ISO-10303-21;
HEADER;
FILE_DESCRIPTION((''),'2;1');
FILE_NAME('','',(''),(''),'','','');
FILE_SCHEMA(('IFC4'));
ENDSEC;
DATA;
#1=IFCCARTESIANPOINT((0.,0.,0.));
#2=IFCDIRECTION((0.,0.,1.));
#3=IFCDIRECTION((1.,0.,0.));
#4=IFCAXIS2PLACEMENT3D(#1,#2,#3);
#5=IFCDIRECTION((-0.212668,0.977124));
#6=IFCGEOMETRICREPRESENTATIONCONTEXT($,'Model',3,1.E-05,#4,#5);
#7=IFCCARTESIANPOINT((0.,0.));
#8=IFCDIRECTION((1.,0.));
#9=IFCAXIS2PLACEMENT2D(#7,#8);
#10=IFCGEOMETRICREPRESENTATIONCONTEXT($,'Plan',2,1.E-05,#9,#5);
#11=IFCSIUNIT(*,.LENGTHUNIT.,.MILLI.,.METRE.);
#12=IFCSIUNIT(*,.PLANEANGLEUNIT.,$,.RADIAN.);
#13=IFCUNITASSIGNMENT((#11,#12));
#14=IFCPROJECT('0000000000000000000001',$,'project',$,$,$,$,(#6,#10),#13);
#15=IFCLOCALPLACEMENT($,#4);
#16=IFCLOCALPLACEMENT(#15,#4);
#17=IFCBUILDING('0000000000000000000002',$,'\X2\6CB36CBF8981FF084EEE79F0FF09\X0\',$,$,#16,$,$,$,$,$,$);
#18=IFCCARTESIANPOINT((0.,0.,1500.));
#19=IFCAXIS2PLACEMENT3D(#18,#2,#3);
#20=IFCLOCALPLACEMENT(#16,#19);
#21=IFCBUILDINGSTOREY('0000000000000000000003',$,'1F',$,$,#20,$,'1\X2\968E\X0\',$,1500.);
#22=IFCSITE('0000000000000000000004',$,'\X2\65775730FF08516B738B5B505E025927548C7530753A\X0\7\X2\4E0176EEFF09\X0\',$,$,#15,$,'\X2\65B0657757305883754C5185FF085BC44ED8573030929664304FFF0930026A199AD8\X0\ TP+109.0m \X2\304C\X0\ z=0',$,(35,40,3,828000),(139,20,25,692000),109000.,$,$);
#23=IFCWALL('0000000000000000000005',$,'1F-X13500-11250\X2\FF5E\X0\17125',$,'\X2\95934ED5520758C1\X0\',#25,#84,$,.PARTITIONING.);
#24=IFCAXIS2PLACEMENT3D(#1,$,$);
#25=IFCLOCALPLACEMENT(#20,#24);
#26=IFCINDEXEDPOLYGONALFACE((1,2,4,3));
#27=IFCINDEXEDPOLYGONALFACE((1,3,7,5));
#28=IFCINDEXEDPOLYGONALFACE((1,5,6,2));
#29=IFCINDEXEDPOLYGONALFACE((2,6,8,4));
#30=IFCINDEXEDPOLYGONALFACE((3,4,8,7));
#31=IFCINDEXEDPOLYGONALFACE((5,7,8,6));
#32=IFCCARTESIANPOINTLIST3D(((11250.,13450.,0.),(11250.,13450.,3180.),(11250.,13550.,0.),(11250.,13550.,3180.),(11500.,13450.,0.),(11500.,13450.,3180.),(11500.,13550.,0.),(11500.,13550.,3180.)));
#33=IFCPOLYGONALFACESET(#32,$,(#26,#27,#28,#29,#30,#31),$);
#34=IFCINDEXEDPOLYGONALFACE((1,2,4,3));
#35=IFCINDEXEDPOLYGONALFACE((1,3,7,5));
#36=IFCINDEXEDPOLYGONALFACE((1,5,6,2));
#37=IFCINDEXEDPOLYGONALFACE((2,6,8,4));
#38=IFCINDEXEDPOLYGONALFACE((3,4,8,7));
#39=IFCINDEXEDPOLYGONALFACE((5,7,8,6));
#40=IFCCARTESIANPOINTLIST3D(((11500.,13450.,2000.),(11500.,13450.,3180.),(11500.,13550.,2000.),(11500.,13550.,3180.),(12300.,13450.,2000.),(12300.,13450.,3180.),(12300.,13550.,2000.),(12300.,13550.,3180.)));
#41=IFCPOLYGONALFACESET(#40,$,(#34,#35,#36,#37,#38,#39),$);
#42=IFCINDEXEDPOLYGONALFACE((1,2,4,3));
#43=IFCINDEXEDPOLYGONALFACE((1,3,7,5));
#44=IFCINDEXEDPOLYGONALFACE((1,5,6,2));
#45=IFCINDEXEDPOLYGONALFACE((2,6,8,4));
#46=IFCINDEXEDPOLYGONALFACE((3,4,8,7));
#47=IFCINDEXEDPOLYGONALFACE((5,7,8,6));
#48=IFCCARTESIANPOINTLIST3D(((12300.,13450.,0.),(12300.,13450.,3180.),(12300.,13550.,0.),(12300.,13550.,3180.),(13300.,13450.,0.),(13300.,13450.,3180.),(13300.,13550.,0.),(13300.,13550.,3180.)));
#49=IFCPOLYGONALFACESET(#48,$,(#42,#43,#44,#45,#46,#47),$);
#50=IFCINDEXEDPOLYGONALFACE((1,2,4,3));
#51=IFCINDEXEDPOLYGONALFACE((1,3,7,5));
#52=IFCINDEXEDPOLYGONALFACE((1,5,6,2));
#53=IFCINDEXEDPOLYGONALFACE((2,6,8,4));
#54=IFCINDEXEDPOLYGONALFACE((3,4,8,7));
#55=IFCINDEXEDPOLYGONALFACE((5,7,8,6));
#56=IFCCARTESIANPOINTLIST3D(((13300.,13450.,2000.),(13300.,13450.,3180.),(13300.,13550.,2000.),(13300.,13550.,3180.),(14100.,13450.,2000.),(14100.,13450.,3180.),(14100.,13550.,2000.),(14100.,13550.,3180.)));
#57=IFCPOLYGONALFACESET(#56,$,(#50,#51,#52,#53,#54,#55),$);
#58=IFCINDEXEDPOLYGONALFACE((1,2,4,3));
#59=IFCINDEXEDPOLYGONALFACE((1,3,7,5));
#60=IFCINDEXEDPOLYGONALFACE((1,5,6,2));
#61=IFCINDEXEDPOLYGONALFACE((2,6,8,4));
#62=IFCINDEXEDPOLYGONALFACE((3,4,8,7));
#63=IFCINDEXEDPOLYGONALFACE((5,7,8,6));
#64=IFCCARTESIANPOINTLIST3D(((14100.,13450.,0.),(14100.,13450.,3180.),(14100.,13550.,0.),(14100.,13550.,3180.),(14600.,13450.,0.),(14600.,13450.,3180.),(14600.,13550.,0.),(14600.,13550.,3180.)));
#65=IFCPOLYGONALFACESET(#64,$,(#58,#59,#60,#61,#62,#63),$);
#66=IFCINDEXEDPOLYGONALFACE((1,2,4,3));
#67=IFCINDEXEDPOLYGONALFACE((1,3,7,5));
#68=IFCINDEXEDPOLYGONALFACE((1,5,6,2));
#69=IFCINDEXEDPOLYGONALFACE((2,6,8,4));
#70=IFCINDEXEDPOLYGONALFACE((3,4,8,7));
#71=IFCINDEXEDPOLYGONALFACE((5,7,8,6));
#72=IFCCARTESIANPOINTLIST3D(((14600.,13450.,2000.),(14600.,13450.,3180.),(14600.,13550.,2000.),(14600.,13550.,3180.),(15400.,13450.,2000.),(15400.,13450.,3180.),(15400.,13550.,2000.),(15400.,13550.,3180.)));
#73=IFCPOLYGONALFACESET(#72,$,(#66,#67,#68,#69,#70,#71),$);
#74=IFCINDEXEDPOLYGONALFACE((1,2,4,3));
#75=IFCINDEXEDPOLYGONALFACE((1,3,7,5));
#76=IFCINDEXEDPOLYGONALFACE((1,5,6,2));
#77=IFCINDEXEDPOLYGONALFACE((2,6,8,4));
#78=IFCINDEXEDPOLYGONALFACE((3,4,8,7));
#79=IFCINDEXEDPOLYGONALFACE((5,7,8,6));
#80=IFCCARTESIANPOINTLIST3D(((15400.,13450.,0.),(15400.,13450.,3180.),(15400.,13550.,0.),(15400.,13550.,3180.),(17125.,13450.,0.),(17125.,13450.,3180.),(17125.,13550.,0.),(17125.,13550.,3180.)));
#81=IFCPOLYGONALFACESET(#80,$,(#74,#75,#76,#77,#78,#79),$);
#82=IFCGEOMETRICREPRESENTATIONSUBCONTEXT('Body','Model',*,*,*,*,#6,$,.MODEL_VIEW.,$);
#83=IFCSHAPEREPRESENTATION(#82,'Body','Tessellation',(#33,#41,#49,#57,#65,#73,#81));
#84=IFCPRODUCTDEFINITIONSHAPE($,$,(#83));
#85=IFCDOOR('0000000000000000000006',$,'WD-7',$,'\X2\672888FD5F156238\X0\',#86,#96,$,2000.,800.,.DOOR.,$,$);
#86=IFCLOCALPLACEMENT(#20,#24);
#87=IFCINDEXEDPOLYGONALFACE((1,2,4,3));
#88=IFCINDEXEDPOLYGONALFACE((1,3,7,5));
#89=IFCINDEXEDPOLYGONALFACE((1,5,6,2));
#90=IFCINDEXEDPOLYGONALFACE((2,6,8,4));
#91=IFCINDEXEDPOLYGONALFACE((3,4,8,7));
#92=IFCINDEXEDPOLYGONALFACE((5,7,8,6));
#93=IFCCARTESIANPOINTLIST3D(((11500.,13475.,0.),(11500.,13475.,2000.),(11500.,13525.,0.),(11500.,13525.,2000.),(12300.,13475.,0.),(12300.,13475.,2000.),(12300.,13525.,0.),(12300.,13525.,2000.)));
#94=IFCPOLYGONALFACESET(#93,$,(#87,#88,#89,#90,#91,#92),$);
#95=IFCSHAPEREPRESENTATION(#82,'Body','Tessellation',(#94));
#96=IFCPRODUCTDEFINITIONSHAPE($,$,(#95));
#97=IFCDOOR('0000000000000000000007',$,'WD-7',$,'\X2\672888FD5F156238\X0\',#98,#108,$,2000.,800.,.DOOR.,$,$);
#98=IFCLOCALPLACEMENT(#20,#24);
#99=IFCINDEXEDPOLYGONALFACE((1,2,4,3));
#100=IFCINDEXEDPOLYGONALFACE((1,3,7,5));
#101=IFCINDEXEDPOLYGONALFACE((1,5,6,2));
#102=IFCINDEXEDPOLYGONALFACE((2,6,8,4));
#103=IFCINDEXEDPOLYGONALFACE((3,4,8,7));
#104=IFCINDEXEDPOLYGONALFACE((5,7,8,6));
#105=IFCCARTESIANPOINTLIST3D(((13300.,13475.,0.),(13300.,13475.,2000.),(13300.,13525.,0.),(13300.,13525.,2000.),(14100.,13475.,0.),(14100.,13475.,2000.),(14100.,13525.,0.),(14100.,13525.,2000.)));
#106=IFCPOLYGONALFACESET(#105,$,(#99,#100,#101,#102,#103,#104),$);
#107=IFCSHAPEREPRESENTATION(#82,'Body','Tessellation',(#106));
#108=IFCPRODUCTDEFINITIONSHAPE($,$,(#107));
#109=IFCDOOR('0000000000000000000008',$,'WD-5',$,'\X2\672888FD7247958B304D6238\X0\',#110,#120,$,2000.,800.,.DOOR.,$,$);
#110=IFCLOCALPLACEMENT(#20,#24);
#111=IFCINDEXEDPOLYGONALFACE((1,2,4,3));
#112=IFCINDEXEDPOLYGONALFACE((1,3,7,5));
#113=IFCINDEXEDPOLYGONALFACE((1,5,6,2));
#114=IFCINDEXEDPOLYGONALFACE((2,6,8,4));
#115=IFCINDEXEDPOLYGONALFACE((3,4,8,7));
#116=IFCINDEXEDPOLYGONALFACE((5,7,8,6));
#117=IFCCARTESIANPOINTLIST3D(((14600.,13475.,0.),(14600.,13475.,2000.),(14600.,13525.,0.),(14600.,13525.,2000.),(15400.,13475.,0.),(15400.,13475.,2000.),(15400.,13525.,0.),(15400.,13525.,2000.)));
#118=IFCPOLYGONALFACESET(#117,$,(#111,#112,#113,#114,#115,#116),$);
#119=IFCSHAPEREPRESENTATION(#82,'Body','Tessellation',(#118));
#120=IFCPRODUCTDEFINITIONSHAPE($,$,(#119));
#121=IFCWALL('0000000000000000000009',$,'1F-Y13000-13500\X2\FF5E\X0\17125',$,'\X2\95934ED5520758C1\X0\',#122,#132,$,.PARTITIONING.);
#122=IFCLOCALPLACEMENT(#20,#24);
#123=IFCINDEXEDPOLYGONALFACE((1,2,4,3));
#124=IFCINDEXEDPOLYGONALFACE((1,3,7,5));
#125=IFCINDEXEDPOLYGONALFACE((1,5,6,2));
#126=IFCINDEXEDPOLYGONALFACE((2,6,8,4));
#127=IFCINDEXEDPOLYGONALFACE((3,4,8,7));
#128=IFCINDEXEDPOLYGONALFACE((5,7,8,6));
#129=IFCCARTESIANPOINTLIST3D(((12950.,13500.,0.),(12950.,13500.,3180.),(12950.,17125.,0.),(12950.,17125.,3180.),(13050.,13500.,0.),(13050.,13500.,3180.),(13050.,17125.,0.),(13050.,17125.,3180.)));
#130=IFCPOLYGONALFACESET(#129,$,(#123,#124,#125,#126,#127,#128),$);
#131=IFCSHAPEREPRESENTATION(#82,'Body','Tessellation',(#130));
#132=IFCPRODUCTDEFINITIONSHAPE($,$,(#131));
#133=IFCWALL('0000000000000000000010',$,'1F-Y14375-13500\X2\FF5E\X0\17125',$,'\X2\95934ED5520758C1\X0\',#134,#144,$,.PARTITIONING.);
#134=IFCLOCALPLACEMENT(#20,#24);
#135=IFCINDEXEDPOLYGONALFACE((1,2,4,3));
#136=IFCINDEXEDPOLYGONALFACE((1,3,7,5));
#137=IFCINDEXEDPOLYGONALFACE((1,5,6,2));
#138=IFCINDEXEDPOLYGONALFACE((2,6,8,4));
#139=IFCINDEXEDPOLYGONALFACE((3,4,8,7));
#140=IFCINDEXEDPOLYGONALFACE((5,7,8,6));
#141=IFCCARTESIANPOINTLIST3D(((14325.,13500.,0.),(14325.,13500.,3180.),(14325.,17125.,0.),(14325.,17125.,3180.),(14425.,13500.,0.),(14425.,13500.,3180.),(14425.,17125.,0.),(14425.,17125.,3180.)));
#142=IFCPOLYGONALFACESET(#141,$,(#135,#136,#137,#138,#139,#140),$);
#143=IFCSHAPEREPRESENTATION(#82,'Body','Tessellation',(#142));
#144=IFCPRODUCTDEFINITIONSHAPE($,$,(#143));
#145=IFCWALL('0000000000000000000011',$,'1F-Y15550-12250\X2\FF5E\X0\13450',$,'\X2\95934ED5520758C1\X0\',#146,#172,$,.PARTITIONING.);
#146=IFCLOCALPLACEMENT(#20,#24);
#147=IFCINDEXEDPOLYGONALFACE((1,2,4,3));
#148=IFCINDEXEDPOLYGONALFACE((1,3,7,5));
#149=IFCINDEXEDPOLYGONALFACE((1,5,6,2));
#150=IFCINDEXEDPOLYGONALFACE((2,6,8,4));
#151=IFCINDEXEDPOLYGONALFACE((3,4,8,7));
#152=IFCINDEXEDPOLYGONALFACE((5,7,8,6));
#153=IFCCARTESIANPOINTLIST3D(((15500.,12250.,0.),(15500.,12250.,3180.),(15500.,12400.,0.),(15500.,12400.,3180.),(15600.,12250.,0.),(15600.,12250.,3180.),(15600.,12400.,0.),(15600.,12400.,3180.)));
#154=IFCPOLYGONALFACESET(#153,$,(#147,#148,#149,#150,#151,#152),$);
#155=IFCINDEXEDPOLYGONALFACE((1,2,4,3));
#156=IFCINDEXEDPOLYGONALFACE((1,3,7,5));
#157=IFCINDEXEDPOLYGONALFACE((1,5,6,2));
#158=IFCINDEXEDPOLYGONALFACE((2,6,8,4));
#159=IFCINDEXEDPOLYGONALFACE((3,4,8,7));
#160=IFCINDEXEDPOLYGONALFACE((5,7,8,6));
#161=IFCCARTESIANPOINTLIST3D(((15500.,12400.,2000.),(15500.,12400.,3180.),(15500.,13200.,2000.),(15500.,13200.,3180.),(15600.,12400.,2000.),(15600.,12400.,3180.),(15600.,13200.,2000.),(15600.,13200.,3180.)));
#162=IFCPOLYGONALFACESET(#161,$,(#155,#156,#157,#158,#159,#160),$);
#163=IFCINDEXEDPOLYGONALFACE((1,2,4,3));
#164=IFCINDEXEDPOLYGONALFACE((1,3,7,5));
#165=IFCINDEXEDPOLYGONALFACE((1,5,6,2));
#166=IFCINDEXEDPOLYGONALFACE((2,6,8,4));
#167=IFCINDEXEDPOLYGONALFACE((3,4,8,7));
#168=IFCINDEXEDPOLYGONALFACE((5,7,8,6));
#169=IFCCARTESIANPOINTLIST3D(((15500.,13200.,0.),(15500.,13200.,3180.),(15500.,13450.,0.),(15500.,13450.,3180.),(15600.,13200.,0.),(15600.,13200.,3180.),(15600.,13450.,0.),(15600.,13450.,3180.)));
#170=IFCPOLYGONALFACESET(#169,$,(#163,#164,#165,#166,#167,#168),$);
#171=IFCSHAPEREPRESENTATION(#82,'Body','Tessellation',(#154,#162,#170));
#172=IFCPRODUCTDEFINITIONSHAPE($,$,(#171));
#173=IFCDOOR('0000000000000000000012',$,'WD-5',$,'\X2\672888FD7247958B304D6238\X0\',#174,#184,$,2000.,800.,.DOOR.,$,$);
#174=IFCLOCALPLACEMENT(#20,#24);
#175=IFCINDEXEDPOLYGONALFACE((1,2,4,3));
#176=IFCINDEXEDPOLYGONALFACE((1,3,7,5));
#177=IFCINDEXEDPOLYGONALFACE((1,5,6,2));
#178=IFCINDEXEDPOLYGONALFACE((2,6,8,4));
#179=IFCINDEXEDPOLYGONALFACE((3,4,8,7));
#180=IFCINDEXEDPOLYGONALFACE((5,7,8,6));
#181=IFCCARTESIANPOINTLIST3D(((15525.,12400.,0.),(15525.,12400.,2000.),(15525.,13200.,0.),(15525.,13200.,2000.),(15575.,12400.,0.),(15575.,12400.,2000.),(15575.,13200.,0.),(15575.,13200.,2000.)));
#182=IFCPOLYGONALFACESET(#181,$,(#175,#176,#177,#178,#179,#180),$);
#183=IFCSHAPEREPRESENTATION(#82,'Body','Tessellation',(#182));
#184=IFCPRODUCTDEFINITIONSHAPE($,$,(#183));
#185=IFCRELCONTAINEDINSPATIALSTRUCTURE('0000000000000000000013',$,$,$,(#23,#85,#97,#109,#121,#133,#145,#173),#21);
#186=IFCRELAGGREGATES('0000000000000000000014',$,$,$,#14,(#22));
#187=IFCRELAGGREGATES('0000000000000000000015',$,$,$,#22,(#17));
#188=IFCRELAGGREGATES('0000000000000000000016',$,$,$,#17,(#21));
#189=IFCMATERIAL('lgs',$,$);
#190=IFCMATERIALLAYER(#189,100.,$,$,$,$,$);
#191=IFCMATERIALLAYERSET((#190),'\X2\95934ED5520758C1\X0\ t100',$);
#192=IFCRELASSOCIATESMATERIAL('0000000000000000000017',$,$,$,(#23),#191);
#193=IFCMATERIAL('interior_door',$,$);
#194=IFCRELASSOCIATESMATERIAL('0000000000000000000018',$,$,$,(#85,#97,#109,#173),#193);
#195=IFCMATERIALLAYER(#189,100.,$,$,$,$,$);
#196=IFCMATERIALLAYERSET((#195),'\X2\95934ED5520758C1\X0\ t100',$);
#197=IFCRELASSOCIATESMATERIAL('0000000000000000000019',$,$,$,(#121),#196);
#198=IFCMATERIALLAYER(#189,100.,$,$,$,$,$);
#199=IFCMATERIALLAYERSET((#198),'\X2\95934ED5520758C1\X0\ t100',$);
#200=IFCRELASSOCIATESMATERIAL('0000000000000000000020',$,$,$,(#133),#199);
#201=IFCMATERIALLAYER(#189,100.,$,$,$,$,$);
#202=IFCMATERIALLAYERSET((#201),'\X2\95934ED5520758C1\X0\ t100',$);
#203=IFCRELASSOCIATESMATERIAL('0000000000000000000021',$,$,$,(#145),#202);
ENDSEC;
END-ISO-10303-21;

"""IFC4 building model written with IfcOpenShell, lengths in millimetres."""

from ifc_helpers import new_model, si_unit, direction, frame, frame_2d, origin, origin_with_axes, origin_2d_with_axis, place, context, subcontext, project, spatial, rectangle, extrude, material, layer, layer_set, layer_usage, element, fill, save


model = new_model("IFC4")

# Units and contexts
model_context = context("Model", 3, precision=1e-05, world=origin_with_axes(), true_north=direction((-0.212668, 0.977124)))
plan_context = context("Plan", 2, precision=1e-05, world=origin_2d_with_axis(), true_north=direction((-0.212668, 0.977124)))
body_context = subcontext(model_context, "Body", "Model", "MODEL_VIEW")
ifc_project = project(units=[si_unit("LENGTHUNIT", "METRE", prefix="MILLI"), si_unit("PLANEANGLEUNIT", "RADIAN")], contexts=[model_context, plan_context])

# Site, building, storey
site_placement = place(None, origin_with_axes())
site = spatial("IfcSite", under=ifc_project, at=site_placement, Name="敷地（八王子市大和田町7丁目）", LongName="新敷地境界内（寄付地を除く）。標高 TP+109.0m が z=0", RefLatitude=(35, 40, 3, 828000), RefLongitude=(139, 20, 25, 692000), RefElevation=109000.0)
building_placement = place(site_placement, origin_with_axes())
building = spatial("IfcBuilding", under=site, at=building_placement, Name="河沿要（仮称）")
storey_placement = place(building_placement, frame((0.0, 0.0, 1500.0), z_axis=(0.0, 0.0, 1.0), x_axis=(1.0, 0.0, 0.0)))
storey = spatial("IfcBuildingStorey", under=building, at=storey_placement, Name="1F", LongName="1階", Elevation=1500.0)

# Shared definitions
ifc_material_1 = material(Name="lgs")

# Wall, openings, doors
ifc_layer_1 = layer(ifc_material_1, 100.0)
ifc_layer_set_1 = layer_set([ifc_layer_1], Name="間仕切壁 t100")
ifc_layer_usage_1 = layer_usage(ifc_layer_set_1, "AXIS2", "POSITIVE", 0.0)
wall_1_placement = place(storey_placement, origin_with_axes())
wall_1 = element("IfcWall", 1, at=wall_1_placement, inside=storey, material=ifc_layer_usage_1, Name="1F-X13500-11250～17125", ObjectType="間仕切壁", PredefinedType="PARTITIONING", context=body_context, shape_type="SweptSolid", body=[
    extrude(rectangle(XDim=250.0, YDim=100.0, at=frame_2d((11375.0, 13500.0))), origin(), (0.0, 0.0, 1.0), 3180.0),
    extrude(rectangle(XDim=800.0, YDim=100.0, at=frame_2d((11900.0, 13500.0))), frame((0.0, 0.0, 2000.0)), (0.0, 0.0, 1.0), 1180.0),
    extrude(rectangle(XDim=1000.0, YDim=100.0, at=frame_2d((12800.0, 13500.0))), origin(), (0.0, 0.0, 1.0), 3180.0),
    extrude(rectangle(XDim=800.0, YDim=100.0, at=frame_2d((13700.0, 13500.0))), frame((0.0, 0.0, 2000.0)), (0.0, 0.0, 1.0), 1180.0),
    extrude(rectangle(XDim=500.0, YDim=100.0, at=frame_2d((14350.0, 13500.0))), origin(), (0.0, 0.0, 1.0), 3180.0),
    extrude(rectangle(XDim=800.0, YDim=100.0, at=frame_2d((15000.0, 13500.0))), frame((0.0, 0.0, 2000.0)), (0.0, 0.0, 1.0), 1180.0),
    extrude(rectangle(XDim=1725.0, YDim=100.0, at=frame_2d((16262.5, 13500.0))), origin(), (0.0, 0.0, 1.0), 3180.0),
])
opening_1_placement = place(storey_placement, origin_with_axes())
opening_1 = element("IfcOpeningElement", 2, at=opening_1_placement, inside=storey, cuts=wall_1, PredefinedType="OPENING", context=body_context, shape_type="SweptSolid", body=[
    extrude(rectangle(XDim=800.0, YDim=150.0, at=frame_2d((11900.0, 13500.0))), origin(), (0.0, 0.0, 1.0), 2000.0),
])
opening_2_placement = place(storey_placement, origin_with_axes())
opening_2 = element("IfcOpeningElement", 3, at=opening_2_placement, inside=storey, cuts=wall_1, PredefinedType="OPENING", context=body_context, shape_type="SweptSolid", body=[
    extrude(rectangle(XDim=800.0, YDim=150.0, at=frame_2d((13700.0, 13500.0))), origin(), (0.0, 0.0, 1.0), 2000.0),
])
opening_3_placement = place(storey_placement, origin_with_axes())
opening_3 = element("IfcOpeningElement", 4, at=opening_3_placement, inside=storey, cuts=wall_1, PredefinedType="OPENING", context=body_context, shape_type="SweptSolid", body=[
    extrude(rectangle(XDim=800.0, YDim=150.0, at=frame_2d((15000.0, 13500.0))), origin(), (0.0, 0.0, 1.0), 2000.0),
])
ifc_material_2 = material(Name="interior_door")
door_1_placement = place(storey_placement, origin_with_axes())
door_1 = element("IfcDoor", 5, at=door_1_placement, inside=storey, material=ifc_material_2, Name="WD-7", ObjectType="木製引戸", OverallHeight=2000.0, OverallWidth=800.0, PredefinedType="DOOR", context=body_context, shape_type="SweptSolid", body=[
    extrude(rectangle(XDim=800.0, YDim=50.0, at=frame_2d((11900.0, 13500.0))), origin(), (0.0, 0.0, 1.0), 2000.0),
])
fill(opening_1, door_1)
door_2_placement = place(storey_placement, origin_with_axes())
door_2 = element("IfcDoor", 6, at=door_2_placement, inside=storey, material=ifc_material_2, Name="WD-7", ObjectType="木製引戸", OverallHeight=2000.0, OverallWidth=800.0, PredefinedType="DOOR", context=body_context, shape_type="SweptSolid", body=[
    extrude(rectangle(XDim=800.0, YDim=50.0, at=frame_2d((13700.0, 13500.0))), origin(), (0.0, 0.0, 1.0), 2000.0),
])
fill(opening_2, door_2)
door_3_placement = place(storey_placement, origin_with_axes())
door_3 = element("IfcDoor", 7, at=door_3_placement, inside=storey, material=ifc_material_2, Name="WD-5", ObjectType="木製片開き戸", OverallHeight=2000.0, OverallWidth=800.0, PredefinedType="DOOR", context=body_context, shape_type="SweptSolid", body=[
    extrude(rectangle(XDim=800.0, YDim=50.0, at=frame_2d((15000.0, 13500.0))), origin(), (0.0, 0.0, 1.0), 2000.0),
])
fill(opening_3, door_3)

# Walls
ifc_layer_2 = layer(ifc_material_1, 100.0)
ifc_layer_set_2 = layer_set([ifc_layer_2], Name="間仕切壁 t100")
ifc_layer_usage_2 = layer_usage(ifc_layer_set_2, "AXIS2", "POSITIVE", 0.0)
wall_2_placement = place(storey_placement, origin_with_axes())
element("IfcWall", 8, at=wall_2_placement, inside=storey, material=ifc_layer_usage_2, Name="1F-Y13000-13500～17125", ObjectType="間仕切壁", PredefinedType="PARTITIONING", context=body_context, shape_type="SweptSolid", body=[
    extrude(rectangle(XDim=100.0, YDim=3625.0, at=frame_2d((13000.0, 15312.5))), origin(), (0.0, 0.0, 1.0), 3180.0),
])
ifc_layer_3 = layer(ifc_material_1, 100.0)
ifc_layer_set_3 = layer_set([ifc_layer_3], Name="間仕切壁 t100")
ifc_layer_usage_3 = layer_usage(ifc_layer_set_3, "AXIS2", "POSITIVE", 0.0)
wall_3_placement = place(storey_placement, origin_with_axes())
element("IfcWall", 9, at=wall_3_placement, inside=storey, material=ifc_layer_usage_3, Name="1F-Y14375-13500～17125", ObjectType="間仕切壁", PredefinedType="PARTITIONING", context=body_context, shape_type="SweptSolid", body=[
    extrude(rectangle(XDim=100.0, YDim=3625.0, at=frame_2d((14375.0, 15312.5))), origin(), (0.0, 0.0, 1.0), 3180.0),
])

# Wall, opening, door
ifc_layer_4 = layer(ifc_material_1, 100.0)
ifc_layer_set_4 = layer_set([ifc_layer_4], Name="間仕切壁 t100")
ifc_layer_usage_4 = layer_usage(ifc_layer_set_4, "AXIS2", "POSITIVE", 0.0)
wall_4_placement = place(storey_placement, origin_with_axes())
wall_4 = element("IfcWall", 10, at=wall_4_placement, inside=storey, material=ifc_layer_usage_4, Name="1F-Y15550-12250～13450", ObjectType="間仕切壁", PredefinedType="PARTITIONING", context=body_context, shape_type="SweptSolid", body=[
    extrude(rectangle(XDim=100.0, YDim=150.0, at=frame_2d((15550.0, 12325.0))), origin(), (0.0, 0.0, 1.0), 3180.0),
    extrude(rectangle(XDim=100.0, YDim=800.0, at=frame_2d((15550.0, 12800.0))), frame((0.0, 0.0, 2000.0)), (0.0, 0.0, 1.0), 1180.0),
    extrude(rectangle(XDim=100.0, YDim=250.0, at=frame_2d((15550.0, 13325.0))), origin(), (0.0, 0.0, 1.0), 3180.0),
])
opening_4_placement = place(storey_placement, origin_with_axes())
opening_4 = element("IfcOpeningElement", 11, at=opening_4_placement, inside=storey, cuts=wall_4, PredefinedType="OPENING", context=body_context, shape_type="SweptSolid", body=[
    extrude(rectangle(XDim=150.0, YDim=800.0, at=frame_2d((15550.0, 12800.0))), origin(), (0.0, 0.0, 1.0), 2000.0),
])
door_4_placement = place(storey_placement, origin_with_axes())
door_4 = element("IfcDoor", 12, at=door_4_placement, inside=storey, material=ifc_material_2, Name="WD-5", ObjectType="木製片開き戸", OverallHeight=2000.0, OverallWidth=800.0, PredefinedType="DOOR", context=body_context, shape_type="SweptSolid", body=[
    extrude(rectangle(XDim=50.0, YDim=800.0, at=frame_2d((15550.0, 12800.0))), origin(), (0.0, 0.0, 1.0), 2000.0),
])
fill(opening_4, door_4)

save(model, "model.ifc")
